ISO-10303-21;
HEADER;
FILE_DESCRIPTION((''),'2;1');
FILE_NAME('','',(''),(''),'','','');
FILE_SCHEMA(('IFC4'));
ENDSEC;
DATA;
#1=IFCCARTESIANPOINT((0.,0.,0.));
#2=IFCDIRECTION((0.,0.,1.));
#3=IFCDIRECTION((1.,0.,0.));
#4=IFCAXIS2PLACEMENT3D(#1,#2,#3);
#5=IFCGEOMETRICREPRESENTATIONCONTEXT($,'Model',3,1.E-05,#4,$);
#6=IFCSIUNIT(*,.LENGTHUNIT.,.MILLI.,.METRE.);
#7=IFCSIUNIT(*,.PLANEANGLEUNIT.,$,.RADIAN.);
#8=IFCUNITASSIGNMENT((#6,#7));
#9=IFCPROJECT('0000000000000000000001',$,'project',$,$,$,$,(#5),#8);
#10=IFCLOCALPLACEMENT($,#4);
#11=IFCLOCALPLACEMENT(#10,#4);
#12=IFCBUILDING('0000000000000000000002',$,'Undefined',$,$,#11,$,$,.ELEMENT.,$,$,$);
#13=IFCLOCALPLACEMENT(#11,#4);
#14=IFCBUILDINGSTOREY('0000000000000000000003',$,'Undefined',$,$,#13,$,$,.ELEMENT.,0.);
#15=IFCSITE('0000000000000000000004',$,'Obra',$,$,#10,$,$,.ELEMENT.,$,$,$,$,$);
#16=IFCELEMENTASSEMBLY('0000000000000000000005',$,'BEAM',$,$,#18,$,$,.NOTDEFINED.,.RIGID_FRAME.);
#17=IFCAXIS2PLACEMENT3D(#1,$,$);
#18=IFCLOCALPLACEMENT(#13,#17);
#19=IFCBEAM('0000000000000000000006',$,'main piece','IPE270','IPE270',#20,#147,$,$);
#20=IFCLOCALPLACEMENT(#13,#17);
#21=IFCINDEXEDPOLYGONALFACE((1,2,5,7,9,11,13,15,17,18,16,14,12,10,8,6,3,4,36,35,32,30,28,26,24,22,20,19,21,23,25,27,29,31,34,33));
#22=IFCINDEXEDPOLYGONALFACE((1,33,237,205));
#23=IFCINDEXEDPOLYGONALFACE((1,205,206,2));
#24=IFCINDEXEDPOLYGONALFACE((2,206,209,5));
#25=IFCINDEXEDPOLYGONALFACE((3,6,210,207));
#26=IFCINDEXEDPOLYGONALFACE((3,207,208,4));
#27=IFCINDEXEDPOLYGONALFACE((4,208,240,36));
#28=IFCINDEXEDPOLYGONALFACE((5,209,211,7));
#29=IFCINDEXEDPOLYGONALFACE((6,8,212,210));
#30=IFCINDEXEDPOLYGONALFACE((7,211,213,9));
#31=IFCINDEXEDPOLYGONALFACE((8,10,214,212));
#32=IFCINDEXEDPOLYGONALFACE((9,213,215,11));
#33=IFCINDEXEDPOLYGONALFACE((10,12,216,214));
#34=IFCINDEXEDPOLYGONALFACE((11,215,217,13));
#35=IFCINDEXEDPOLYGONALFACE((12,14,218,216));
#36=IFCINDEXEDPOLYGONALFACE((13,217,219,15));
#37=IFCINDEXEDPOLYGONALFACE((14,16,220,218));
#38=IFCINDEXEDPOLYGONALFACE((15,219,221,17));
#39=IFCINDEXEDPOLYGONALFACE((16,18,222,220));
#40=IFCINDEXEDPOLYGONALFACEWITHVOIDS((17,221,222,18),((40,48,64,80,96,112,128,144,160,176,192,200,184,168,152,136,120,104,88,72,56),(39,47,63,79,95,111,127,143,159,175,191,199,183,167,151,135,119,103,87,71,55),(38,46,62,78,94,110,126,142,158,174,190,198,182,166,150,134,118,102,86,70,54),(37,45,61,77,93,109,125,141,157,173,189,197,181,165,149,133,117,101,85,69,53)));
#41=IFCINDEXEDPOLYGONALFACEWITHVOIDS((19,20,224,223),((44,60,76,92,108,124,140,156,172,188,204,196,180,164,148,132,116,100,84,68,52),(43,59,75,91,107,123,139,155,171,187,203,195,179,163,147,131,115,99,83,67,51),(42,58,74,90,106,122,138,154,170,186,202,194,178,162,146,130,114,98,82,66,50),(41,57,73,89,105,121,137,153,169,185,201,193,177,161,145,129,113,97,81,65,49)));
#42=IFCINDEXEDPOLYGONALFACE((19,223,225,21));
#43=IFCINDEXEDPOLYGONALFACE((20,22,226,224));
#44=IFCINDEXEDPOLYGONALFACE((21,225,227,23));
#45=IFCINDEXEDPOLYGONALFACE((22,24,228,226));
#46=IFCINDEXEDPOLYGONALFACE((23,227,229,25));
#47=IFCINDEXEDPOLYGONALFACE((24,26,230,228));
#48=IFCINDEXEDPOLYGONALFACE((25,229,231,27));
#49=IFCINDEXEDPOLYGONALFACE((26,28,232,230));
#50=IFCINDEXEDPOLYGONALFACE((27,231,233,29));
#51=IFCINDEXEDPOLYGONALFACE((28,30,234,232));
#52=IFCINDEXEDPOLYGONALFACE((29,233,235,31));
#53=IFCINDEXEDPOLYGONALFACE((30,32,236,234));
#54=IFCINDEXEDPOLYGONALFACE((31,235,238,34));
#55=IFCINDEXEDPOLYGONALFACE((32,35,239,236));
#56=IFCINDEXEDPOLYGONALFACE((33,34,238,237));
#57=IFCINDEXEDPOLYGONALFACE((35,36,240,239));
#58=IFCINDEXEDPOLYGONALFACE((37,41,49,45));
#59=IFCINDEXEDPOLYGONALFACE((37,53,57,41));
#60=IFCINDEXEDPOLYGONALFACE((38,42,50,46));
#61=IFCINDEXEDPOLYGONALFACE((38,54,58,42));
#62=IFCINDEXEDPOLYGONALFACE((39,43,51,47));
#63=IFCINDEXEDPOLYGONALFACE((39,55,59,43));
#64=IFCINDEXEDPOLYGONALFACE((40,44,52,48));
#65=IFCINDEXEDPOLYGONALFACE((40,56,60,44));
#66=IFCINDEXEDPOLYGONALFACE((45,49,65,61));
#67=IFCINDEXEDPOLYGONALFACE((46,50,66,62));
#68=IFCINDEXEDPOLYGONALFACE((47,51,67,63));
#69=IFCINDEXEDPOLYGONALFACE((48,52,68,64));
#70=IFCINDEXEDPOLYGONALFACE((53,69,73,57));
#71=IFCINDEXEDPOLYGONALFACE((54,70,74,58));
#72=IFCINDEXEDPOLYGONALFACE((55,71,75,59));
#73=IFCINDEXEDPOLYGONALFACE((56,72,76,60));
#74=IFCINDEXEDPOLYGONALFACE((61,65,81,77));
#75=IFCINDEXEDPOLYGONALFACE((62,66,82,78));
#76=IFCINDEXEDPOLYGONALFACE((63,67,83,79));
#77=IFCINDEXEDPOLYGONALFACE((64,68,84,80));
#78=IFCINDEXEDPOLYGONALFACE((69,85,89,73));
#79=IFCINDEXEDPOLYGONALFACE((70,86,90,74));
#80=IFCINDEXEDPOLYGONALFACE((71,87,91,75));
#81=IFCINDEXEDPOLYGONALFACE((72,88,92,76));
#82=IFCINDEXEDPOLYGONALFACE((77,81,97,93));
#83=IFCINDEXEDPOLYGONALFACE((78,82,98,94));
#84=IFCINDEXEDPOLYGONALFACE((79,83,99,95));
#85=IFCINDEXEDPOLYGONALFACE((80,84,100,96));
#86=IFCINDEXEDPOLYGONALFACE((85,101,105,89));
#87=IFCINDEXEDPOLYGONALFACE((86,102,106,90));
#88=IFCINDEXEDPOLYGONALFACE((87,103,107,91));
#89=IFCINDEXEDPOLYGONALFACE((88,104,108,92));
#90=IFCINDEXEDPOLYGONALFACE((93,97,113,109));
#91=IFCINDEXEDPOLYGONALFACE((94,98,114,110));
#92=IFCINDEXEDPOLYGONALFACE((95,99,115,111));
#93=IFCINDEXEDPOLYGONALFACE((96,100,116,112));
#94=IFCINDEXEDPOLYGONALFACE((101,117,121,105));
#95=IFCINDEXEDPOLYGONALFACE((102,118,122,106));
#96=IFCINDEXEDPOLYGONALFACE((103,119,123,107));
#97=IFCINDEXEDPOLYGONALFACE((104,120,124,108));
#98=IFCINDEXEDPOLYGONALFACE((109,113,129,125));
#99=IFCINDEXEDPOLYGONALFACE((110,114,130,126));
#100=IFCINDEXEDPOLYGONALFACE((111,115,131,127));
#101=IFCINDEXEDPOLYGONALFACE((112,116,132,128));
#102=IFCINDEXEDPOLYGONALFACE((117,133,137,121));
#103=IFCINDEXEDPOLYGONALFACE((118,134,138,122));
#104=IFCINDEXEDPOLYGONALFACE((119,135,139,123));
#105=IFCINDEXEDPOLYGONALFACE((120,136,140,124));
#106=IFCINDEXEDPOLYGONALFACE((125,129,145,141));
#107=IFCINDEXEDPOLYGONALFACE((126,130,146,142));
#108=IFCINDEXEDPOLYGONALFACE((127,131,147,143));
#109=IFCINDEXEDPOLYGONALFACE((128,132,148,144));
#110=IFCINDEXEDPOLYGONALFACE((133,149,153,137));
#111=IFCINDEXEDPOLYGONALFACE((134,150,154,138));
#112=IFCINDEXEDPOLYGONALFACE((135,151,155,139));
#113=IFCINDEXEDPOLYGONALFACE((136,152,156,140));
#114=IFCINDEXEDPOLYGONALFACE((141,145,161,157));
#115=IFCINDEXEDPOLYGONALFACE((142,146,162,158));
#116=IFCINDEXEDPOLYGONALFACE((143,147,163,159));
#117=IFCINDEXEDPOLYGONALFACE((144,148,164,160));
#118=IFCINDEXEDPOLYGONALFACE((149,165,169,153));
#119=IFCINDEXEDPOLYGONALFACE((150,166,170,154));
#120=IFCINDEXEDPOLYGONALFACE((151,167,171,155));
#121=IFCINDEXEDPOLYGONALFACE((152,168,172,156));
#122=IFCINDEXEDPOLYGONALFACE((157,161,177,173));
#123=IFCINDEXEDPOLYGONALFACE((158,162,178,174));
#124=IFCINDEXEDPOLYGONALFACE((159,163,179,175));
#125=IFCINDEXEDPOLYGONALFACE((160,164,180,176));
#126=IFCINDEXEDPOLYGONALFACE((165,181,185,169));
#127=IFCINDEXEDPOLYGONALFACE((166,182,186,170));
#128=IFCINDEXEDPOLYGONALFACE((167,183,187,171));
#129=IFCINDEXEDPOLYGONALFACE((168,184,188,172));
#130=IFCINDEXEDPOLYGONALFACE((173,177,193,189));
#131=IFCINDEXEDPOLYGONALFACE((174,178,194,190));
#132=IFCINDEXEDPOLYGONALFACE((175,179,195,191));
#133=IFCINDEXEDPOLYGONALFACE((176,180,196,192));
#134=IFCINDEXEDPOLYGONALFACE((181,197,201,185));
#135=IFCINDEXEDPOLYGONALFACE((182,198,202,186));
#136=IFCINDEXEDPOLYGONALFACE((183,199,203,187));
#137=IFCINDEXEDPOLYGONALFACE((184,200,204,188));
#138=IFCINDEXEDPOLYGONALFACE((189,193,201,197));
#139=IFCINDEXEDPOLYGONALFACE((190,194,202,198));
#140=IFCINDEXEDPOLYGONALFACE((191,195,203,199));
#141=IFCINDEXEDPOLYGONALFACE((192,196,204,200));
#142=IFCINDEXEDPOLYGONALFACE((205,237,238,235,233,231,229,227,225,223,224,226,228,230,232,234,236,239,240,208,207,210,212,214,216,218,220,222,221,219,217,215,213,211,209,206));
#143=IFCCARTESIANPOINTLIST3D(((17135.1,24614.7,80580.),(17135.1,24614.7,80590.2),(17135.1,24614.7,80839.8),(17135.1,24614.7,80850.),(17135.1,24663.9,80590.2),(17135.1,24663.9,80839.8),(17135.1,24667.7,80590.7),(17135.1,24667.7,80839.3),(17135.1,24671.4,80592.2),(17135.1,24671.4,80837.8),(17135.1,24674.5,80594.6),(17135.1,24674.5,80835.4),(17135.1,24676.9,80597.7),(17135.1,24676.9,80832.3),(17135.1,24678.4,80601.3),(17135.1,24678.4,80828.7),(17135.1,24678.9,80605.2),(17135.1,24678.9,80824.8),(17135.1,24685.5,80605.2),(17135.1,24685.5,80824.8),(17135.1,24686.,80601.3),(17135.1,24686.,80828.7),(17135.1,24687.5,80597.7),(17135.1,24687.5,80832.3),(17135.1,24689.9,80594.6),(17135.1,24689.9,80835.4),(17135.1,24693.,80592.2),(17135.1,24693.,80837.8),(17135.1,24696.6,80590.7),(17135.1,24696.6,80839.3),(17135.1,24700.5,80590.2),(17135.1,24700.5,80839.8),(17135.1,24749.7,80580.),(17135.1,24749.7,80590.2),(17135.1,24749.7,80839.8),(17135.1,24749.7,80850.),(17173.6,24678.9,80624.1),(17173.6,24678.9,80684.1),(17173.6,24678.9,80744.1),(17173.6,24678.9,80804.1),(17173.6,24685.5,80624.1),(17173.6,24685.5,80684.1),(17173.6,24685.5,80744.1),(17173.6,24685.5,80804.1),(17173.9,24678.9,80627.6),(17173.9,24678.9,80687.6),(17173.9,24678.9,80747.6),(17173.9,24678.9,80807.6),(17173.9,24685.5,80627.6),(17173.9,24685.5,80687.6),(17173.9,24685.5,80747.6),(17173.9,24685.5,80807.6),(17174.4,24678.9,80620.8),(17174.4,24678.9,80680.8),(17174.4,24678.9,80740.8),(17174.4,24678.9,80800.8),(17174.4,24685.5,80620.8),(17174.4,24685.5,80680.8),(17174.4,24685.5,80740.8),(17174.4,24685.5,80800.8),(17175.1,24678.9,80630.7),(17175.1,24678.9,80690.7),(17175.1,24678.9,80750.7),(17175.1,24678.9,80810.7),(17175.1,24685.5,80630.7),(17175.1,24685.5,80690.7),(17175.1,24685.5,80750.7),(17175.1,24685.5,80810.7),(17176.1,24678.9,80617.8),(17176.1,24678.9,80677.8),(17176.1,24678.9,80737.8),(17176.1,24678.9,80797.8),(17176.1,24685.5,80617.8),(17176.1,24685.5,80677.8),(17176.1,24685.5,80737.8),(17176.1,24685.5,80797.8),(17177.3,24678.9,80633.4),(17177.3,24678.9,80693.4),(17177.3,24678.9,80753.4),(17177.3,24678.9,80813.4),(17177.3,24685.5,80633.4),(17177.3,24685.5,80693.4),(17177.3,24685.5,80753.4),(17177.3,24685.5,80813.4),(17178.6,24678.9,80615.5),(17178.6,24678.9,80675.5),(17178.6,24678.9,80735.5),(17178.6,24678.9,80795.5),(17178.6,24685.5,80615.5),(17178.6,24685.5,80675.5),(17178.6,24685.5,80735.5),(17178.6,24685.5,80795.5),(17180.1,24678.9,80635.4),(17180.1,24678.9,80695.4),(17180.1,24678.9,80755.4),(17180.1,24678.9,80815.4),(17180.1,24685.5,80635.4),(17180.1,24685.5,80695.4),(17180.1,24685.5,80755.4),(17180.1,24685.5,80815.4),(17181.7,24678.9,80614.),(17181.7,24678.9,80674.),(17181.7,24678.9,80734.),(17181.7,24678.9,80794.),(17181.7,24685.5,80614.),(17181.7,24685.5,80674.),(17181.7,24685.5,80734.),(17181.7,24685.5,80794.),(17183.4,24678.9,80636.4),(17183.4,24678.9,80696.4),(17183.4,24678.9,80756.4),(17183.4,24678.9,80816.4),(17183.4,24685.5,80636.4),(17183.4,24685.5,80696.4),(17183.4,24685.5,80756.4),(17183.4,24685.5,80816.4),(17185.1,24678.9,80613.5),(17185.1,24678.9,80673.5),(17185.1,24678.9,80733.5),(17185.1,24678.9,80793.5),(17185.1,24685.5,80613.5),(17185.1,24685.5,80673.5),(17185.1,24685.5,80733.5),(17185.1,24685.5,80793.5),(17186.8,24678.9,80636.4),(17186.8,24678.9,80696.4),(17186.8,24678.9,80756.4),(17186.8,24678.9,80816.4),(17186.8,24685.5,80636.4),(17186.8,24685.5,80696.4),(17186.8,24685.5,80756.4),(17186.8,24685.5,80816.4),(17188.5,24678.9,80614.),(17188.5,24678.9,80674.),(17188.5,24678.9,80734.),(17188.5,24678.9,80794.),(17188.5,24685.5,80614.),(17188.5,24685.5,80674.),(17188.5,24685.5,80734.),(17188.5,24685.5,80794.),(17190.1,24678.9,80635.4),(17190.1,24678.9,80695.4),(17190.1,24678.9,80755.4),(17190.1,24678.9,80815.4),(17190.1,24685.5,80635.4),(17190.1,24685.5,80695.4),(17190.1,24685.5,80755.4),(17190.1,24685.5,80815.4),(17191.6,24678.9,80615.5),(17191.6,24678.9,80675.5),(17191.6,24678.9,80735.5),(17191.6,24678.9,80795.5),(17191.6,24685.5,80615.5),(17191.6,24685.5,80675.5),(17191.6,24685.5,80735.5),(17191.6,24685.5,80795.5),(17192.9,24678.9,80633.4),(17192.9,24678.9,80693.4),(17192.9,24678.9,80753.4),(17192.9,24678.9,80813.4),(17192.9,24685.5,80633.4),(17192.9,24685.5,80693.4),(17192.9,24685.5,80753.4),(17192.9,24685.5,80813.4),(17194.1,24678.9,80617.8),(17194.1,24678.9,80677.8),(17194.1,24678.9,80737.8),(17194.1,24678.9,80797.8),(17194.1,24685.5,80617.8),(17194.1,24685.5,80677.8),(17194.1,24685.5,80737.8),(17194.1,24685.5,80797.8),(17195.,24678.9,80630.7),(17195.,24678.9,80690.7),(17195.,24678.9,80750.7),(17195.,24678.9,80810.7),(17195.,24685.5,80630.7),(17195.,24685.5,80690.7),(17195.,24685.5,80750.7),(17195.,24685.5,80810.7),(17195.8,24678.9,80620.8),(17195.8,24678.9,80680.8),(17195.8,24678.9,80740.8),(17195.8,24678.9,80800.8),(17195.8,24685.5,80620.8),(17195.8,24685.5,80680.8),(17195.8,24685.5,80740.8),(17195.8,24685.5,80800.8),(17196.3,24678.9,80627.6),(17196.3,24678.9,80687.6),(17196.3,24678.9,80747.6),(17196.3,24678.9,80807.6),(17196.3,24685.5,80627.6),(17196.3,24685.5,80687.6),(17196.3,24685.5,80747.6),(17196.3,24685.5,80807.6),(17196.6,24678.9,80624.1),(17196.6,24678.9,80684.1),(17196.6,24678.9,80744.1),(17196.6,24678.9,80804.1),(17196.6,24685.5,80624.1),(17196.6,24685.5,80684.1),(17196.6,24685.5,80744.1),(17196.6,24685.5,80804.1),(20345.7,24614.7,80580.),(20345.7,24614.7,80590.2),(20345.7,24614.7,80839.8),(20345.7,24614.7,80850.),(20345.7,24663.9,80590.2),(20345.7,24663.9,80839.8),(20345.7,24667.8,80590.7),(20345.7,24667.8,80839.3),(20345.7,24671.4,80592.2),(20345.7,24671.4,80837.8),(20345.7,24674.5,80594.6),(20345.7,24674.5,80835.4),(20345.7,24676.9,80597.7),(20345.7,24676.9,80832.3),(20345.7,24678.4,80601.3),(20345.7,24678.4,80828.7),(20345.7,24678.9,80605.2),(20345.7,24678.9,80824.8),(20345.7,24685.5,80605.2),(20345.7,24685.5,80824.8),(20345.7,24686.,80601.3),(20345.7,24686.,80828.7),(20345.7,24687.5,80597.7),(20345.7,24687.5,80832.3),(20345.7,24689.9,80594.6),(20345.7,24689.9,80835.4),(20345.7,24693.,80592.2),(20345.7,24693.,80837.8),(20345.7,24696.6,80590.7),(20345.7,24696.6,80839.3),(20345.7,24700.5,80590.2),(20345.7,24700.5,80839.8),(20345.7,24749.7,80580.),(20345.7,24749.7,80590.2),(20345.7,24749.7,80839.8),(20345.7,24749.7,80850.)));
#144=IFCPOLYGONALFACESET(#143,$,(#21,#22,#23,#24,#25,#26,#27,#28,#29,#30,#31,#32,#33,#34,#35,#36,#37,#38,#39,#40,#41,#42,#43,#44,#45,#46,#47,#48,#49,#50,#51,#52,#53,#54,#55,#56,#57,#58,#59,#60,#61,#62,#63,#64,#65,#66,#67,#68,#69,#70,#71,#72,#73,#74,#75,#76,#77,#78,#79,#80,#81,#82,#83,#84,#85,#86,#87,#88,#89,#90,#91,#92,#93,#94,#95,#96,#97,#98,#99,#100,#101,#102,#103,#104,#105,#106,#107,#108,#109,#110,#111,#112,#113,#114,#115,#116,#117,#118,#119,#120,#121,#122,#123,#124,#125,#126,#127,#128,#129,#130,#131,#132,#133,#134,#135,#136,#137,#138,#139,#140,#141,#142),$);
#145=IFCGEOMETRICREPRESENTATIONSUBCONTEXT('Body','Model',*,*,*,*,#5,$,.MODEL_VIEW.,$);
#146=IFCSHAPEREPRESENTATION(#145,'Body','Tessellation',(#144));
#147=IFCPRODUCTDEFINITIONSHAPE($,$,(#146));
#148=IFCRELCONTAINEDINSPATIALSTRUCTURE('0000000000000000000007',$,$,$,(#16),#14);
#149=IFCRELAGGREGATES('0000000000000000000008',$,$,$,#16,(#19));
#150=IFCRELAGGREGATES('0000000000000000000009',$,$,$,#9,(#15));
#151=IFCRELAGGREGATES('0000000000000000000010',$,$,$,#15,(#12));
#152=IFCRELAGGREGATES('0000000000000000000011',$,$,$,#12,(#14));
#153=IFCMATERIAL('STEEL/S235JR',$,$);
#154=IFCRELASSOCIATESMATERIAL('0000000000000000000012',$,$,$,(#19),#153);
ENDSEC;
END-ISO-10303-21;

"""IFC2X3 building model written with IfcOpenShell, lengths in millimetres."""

from ifc_helpers import new_model, si_unit, frame, origin_with_axes, origin_2d_with_axis, place, context, subcontext, project, spatial, circle, i_section, extrude, clip, halfspace, source, transform, mapped, material, element, aggregate, save


model = new_model("IFC2X3")

# Units and contexts
model_context = context("Model", 3, precision=1e-05, world=origin_with_axes())
body_context = subcontext(model_context, "Body", "Model", "MODEL_VIEW")
ifc_project = project(units=[si_unit("LENGTHUNIT", "METRE", prefix="MILLI"), si_unit("PLANEANGLEUNIT", "RADIAN")], contexts=[model_context])

# Site, building, storey
site_placement = place(None, origin_with_axes())
site = spatial("IfcSite", under=ifc_project, at=site_placement, Name="Obra", CompositionType="ELEMENT")
building_placement = place(site_placement, origin_with_axes())
building = spatial("IfcBuilding", under=site, at=building_placement, Name="Undefined", CompositionType="ELEMENT")
storey_placement = place(building_placement, origin_with_axes())
storey = spatial("IfcBuildingStorey", under=building, at=storey_placement, Name="Undefined", CompositionType="ELEMENT", Elevation=0.0)

# Shared definitions
ifc_material = material(Name="STEEL/S235JR")

# Element assembly, beam, opening
assembly_1_placement = place(storey_placement, origin_with_axes())
assembly_1 = element("IfcElementAssembly", 1, at=assembly_1_placement, inside=storey, Name="BEAM", AssemblyPlace="NOTDEFINED", PredefinedType="RIGID_FRAME")
beam_1_placement = place(assembly_1_placement, frame((17145.0, 24682.2, 80715.0), z_axis=(0.0, 0.0, 1.0), x_axis=(1.0, 0.000001, 0.0)))
beam_1 = element("IfcBeam", 2, at=beam_1_placement, material=ifc_material, Name="main piece", Description="IPE270", ObjectType="IPE270", context=body_context, shape_type="Clipping", body=[
    clip(extrude(i_section(OverallWidth=135.0, OverallDepth=270.0, WebThickness=6.6, FlangeThickness=10.2, FilletRadius=15.0, at=origin_2d_with_axis()), frame((3200.7, 0.0, 0.0), z_axis=(-1.0, 0.0, 0.0), x_axis=(0.0, -1.0, 0.0)), (0.0, 0.0, 1.0), 3210.6), halfspace(frame((-9.9, 0.0, -235.0), z_axis=(1.0, -0.000002, 0.0), x_axis=(-0.000002, -1.0, 0.0)), True)),
])
shared_shape_1 = source(origin_with_axes(), body_context, "Body", "SweptSolid", [
    extrude(circle(Radius=11.5, at=origin_2d_with_axis()), frame((0.0, -3.4, 0.0), z_axis=(0.0, 1.0, 0.0), x_axis=(1.0, 0.0, 0.0)), (0.0, 0.0, 1.0), 6.8),
])
opening_1_placement = place(assembly_1_placement, frame((17135.1, 24682.2, 80850.0), z_axis=(1.0, 0.0, 0.0), x_axis=(0.0, 0.0, -1.0)))
element("IfcOpeningElement", 3, at=opening_1_placement, cuts=beam_1, ObjectType="Opening", context=body_context, shape_type="MappedRepresentation", body=[
    mapped(shared_shape_1, transform((45.0, 0.0, 50.0))),
    mapped(shared_shape_1, transform((105.0, 0.0, 50.0))),
    mapped(shared_shape_1, transform((165.0, 0.0, 50.0))),
    mapped(shared_shape_1, transform((225.0, 0.0, 50.0))),
])
aggregate(assembly_1, [beam_1])

save(model, "model.ifc")
